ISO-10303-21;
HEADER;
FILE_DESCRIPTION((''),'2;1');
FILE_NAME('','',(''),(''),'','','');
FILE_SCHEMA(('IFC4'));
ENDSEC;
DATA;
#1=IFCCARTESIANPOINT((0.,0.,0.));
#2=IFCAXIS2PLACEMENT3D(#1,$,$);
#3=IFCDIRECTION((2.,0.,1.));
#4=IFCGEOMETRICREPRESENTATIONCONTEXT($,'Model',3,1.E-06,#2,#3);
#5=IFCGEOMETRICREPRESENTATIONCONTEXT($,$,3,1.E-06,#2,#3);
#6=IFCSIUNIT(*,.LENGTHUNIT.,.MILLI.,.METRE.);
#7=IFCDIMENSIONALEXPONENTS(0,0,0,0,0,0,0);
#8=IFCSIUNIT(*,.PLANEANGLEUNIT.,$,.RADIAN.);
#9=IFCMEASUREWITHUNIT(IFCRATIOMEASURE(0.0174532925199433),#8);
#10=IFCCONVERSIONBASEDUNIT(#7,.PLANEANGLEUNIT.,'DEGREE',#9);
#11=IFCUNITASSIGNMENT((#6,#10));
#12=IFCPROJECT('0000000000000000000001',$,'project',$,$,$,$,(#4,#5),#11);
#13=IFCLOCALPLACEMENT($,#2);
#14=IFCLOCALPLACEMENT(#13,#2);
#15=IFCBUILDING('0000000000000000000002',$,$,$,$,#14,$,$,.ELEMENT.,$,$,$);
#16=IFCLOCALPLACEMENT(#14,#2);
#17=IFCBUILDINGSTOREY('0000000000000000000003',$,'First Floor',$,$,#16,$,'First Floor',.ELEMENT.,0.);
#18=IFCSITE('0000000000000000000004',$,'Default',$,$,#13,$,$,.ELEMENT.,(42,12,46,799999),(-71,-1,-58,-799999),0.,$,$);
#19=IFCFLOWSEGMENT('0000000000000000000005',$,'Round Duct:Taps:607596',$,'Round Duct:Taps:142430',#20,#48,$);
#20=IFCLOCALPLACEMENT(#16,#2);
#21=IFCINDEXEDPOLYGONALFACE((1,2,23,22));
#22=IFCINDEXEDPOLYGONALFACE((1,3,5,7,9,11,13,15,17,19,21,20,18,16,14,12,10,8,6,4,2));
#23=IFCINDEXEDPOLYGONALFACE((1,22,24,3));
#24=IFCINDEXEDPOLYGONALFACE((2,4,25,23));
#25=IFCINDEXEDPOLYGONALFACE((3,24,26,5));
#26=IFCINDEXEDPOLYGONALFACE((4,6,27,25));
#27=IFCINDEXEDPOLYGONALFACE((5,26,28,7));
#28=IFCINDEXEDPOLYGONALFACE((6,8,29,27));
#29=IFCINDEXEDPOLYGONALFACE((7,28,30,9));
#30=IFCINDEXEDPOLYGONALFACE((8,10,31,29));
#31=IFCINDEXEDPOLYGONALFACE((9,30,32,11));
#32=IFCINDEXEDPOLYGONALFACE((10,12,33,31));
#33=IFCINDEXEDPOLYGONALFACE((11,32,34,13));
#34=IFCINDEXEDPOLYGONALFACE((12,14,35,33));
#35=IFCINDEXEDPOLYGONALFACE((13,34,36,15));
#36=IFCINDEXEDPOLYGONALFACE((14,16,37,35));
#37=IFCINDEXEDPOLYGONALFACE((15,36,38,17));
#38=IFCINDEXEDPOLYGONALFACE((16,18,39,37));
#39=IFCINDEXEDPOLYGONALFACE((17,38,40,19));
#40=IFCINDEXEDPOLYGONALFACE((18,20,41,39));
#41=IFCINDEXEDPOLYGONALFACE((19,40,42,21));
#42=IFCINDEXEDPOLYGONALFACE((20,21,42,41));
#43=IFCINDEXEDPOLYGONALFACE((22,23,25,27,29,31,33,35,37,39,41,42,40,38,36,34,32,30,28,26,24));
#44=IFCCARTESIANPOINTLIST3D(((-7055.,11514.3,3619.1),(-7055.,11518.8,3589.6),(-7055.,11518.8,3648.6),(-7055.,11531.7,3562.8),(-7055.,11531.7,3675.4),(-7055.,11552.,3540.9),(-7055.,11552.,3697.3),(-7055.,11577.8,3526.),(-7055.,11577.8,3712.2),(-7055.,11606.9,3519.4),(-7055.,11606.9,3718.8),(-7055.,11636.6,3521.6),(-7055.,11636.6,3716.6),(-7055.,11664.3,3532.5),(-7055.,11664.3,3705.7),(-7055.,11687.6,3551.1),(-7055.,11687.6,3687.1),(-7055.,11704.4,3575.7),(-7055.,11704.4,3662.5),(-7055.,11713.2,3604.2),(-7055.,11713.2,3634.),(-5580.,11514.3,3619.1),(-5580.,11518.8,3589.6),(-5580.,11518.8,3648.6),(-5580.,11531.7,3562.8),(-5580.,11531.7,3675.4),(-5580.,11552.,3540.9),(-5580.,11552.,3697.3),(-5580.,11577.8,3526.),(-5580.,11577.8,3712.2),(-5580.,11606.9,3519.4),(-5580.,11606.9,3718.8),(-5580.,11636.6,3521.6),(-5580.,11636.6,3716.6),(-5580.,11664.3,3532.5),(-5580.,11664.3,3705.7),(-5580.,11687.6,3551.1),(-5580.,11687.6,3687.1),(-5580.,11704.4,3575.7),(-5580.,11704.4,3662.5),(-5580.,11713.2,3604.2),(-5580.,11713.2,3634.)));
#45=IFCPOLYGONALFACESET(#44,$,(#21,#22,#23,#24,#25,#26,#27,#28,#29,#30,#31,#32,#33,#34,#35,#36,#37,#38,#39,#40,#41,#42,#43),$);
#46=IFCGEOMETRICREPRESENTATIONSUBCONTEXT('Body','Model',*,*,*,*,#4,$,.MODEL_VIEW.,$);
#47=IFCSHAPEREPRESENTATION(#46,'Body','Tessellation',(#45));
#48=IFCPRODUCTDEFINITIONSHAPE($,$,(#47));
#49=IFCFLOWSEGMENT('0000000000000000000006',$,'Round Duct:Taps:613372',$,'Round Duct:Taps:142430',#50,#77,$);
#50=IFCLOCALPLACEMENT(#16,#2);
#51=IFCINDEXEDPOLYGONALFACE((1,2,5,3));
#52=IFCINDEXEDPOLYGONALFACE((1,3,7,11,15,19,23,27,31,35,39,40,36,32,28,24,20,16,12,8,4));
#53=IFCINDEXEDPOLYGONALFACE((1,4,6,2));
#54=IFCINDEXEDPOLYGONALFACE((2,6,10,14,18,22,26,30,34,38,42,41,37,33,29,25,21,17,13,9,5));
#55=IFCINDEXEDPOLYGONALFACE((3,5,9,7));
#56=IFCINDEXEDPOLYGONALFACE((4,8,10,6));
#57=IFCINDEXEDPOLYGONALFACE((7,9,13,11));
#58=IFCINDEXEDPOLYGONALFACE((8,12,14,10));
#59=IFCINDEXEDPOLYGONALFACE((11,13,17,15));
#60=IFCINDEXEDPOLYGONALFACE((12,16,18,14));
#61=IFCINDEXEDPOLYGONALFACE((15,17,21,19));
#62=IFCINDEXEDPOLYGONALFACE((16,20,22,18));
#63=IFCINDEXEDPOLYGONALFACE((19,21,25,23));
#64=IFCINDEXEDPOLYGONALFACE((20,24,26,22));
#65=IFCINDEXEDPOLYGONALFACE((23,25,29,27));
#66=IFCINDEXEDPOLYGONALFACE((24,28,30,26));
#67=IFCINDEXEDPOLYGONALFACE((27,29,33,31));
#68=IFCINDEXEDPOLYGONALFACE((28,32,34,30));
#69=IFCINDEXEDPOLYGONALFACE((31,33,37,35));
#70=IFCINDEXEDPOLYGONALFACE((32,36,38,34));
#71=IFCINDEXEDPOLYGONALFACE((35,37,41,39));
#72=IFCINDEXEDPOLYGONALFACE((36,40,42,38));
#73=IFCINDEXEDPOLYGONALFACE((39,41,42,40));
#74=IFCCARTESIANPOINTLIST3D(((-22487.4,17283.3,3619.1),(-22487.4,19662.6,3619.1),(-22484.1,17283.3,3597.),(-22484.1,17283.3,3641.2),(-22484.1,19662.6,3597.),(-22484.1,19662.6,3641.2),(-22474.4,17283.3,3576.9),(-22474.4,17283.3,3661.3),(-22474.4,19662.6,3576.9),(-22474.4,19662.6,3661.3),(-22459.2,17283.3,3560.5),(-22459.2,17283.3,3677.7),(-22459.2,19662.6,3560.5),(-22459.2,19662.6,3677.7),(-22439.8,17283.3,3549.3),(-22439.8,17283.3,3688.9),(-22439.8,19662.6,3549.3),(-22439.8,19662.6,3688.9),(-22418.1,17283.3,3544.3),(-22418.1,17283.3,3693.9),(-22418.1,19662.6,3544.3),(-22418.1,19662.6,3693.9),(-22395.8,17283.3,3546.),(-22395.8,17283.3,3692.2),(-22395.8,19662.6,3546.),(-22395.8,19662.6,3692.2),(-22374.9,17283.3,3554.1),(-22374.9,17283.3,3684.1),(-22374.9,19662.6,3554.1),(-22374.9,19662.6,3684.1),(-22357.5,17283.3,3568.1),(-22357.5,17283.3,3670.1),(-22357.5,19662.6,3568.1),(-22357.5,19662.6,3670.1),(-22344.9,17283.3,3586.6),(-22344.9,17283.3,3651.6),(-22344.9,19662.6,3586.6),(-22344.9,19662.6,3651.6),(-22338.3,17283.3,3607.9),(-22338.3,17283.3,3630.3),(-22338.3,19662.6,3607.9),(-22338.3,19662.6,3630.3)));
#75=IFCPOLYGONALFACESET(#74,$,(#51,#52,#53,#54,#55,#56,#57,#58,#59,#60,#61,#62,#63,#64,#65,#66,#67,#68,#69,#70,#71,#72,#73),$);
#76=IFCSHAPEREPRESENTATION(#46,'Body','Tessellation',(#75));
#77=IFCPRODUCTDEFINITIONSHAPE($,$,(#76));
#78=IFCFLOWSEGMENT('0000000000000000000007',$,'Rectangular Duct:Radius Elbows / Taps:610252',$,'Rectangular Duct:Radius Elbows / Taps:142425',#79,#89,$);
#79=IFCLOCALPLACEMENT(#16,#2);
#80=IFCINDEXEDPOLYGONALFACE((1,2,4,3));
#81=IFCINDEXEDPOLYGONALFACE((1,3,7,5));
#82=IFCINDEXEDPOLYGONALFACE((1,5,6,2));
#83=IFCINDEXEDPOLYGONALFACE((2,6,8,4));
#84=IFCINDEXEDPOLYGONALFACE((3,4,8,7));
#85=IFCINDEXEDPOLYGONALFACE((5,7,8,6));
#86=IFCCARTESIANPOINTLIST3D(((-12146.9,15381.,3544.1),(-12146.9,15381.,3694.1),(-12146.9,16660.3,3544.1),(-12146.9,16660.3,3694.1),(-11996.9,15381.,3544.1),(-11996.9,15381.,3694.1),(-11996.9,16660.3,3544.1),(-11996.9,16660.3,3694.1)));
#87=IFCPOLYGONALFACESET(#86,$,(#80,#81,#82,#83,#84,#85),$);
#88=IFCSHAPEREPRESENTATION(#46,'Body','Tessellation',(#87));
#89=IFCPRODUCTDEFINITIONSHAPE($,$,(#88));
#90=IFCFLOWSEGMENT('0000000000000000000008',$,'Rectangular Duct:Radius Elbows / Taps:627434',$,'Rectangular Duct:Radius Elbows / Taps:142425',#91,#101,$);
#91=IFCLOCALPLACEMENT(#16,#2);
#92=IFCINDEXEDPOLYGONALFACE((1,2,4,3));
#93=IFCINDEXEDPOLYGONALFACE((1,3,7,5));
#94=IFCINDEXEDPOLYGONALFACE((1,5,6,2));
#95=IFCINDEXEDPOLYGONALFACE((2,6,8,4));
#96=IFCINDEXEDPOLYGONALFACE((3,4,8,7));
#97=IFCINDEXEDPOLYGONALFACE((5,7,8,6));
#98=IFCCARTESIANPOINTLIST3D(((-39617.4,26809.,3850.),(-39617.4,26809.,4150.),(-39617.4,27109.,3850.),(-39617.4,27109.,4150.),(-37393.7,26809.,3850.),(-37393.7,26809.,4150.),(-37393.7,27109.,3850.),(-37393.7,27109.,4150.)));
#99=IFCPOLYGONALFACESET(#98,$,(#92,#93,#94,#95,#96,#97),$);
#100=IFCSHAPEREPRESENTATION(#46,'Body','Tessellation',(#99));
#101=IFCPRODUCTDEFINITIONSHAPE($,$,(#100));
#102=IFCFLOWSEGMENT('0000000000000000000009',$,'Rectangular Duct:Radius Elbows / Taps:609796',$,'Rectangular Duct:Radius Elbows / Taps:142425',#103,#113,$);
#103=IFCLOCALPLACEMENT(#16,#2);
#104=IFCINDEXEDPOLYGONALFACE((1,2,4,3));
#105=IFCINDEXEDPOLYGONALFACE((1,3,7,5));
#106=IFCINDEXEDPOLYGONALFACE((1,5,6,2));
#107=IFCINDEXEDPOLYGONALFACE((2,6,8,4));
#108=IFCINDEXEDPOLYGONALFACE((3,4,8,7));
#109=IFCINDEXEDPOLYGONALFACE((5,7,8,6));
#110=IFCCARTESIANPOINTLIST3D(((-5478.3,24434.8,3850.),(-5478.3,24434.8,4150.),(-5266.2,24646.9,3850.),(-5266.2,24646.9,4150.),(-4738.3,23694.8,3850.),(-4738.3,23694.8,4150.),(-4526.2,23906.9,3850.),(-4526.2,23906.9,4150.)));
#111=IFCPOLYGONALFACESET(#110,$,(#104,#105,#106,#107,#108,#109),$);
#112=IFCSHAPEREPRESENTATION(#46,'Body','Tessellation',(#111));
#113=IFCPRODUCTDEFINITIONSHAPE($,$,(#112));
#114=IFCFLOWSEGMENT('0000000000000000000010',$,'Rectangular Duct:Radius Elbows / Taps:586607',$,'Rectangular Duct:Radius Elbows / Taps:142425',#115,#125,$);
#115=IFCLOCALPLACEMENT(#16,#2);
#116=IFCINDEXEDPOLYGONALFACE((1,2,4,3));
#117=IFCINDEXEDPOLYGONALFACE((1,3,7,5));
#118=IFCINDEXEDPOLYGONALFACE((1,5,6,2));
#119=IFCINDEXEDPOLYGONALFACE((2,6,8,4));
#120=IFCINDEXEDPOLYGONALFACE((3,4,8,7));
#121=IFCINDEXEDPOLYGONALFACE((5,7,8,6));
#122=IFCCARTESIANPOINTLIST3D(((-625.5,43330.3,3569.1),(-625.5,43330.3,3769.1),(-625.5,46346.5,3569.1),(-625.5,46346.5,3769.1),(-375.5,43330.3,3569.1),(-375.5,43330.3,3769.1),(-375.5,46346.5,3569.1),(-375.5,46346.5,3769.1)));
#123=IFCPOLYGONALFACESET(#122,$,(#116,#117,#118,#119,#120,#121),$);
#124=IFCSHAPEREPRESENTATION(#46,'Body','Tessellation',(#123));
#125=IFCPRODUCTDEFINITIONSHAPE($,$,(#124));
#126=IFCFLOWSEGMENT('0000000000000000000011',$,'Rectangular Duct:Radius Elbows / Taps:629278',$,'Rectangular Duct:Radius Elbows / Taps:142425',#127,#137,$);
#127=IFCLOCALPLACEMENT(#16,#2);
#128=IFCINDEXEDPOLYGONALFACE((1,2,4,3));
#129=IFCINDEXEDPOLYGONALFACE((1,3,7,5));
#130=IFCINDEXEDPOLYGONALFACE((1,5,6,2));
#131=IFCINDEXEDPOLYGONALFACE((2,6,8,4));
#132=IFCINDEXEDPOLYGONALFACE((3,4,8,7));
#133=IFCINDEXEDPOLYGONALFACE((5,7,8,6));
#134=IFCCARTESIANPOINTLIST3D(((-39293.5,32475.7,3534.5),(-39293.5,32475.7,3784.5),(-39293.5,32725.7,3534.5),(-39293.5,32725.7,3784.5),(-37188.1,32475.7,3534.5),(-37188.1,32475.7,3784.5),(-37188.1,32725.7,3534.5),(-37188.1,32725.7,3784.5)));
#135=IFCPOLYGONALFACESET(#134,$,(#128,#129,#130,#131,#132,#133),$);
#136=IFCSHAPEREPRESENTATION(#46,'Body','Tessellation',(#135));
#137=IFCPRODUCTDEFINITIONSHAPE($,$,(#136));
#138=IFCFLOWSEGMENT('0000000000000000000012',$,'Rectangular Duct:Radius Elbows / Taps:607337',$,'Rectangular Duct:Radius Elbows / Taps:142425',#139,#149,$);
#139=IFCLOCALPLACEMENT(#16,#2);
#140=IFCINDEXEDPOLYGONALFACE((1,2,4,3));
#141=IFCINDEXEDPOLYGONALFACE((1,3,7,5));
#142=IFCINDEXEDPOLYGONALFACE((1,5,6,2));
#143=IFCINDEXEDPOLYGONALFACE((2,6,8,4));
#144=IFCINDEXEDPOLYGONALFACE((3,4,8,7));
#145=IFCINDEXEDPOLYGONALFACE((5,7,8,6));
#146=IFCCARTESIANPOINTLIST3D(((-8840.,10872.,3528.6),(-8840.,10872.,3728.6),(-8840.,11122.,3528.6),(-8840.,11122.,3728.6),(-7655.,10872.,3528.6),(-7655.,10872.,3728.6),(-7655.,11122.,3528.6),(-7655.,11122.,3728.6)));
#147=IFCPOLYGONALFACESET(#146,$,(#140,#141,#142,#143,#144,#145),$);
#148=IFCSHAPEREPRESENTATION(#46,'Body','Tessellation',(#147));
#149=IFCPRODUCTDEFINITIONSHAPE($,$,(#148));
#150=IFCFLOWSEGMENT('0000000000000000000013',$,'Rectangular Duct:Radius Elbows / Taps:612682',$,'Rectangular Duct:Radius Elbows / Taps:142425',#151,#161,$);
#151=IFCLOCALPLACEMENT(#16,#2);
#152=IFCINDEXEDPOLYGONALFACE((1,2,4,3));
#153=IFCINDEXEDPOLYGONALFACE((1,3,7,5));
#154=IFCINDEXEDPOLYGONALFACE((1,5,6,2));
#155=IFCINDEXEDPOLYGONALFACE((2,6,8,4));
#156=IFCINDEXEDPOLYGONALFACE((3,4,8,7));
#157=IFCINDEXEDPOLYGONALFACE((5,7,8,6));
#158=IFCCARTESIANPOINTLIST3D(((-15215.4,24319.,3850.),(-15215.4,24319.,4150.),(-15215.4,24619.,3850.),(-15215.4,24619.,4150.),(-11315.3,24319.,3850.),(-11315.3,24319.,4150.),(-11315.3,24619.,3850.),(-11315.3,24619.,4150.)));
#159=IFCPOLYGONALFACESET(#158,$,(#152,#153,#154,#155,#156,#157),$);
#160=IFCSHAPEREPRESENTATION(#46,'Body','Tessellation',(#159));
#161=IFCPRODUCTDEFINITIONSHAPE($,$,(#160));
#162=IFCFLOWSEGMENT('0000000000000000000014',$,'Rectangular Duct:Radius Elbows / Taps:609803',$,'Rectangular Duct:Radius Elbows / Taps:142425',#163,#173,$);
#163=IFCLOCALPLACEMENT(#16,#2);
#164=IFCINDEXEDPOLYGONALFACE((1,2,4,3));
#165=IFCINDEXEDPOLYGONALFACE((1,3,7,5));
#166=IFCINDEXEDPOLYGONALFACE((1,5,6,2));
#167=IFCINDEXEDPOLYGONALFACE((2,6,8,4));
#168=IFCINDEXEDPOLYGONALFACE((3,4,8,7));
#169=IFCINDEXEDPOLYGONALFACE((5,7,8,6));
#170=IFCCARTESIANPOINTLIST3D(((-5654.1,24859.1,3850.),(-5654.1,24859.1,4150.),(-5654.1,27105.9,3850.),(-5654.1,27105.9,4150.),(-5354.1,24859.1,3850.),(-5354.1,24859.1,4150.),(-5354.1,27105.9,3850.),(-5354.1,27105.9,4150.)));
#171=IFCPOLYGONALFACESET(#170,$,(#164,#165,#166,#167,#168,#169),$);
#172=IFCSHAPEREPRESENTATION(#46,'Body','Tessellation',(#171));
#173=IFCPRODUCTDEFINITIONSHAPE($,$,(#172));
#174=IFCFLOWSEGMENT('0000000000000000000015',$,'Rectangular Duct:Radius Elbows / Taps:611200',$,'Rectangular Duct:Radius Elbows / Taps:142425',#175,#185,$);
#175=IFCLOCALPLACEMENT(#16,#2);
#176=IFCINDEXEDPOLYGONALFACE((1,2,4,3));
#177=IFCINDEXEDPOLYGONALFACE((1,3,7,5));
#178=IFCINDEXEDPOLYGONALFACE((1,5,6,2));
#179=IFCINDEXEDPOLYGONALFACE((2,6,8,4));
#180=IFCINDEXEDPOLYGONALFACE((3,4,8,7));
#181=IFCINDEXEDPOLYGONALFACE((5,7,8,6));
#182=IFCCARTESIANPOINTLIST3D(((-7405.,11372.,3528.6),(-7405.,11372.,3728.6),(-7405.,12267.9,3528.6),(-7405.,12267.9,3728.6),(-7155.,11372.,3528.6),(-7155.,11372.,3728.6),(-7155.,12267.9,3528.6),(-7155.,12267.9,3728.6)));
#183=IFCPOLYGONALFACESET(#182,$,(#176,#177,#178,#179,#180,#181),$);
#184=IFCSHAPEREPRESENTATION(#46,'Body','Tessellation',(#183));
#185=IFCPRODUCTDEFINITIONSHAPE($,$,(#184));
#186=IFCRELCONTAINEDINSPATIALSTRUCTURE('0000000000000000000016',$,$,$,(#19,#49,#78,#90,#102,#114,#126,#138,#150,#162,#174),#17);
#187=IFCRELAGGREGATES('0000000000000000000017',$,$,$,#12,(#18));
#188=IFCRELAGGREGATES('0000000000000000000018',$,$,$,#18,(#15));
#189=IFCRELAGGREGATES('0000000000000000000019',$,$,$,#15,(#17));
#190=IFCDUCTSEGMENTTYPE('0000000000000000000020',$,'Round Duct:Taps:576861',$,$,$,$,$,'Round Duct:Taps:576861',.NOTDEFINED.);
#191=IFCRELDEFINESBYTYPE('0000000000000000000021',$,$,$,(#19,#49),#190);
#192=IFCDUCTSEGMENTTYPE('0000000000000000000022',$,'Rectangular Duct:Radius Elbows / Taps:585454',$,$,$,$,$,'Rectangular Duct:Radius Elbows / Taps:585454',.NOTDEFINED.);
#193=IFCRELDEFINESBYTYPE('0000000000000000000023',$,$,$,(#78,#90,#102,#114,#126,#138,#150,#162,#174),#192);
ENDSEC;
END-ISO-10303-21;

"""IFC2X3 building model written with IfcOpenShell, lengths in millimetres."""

from ifc_helpers import new_model, entity, si_unit, converted_unit, direction, frame, frame_2d, origin, origin_2d_with_axis, place, context, subcontext, project, spatial, rectangle, circle, extrude, type_object, element, save


model = new_model("IFC2X3")

# Units and contexts
model_context = context("Model", 3, precision=1e-06, world=origin(), true_north=direction((2.0, 0.0, 1.0)))
context_of_model = context(None, 3, precision=1e-06, world=origin(), true_north=direction((2.0, 0.0, 1.0)))
body_context = subcontext(model_context, "Body", "Model", "MODEL_VIEW")
ifc_project = project(units=[si_unit("LENGTHUNIT", "METRE", prefix="MILLI"), converted_unit("PLANEANGLEUNIT", "DEGREE", entity("IfcRatioMeasure", 0.0174532925199433), si_unit("PLANEANGLEUNIT", "RADIAN"), dimensions=[0, 0, 0, 0, 0, 0, 0])], contexts=[model_context, context_of_model])

# Site, building, storey
site_placement = place(None, origin())
site = spatial("IfcSite", under=ifc_project, at=site_placement, Name="Default", CompositionType="ELEMENT", RefLatitude=(42, 12, 46, 799999), RefLongitude=(-71, -1, -58, -799999), RefElevation=0.0)
building_placement = place(site_placement, origin())
building = spatial("IfcBuilding", under=site, at=building_placement, CompositionType="ELEMENT")
storey_placement = place(building_placement, origin())
storey = spatial("IfcBuildingStorey", under=building, at=storey_placement, Name="First Floor", LongName="First Floor", CompositionType="ELEMENT", Elevation=0.0)

# Flow segments
duct_segment_type_1 = type_object("IfcDuctSegmentType", Name="Round Duct:Taps:576861", ElementType="Round Duct:Taps:576861", PredefinedType="NOTDEFINED")
flow_segment_1_placement = place(storey_placement, origin())
element("IfcFlowSegment", 1, at=flow_segment_1_placement, inside=storey, type_object=duct_segment_type_1, Name="Round Duct:Taps:607596", ObjectType="Round Duct:Taps:142430", context=body_context, shape_type="SweptSolid", body=[
    extrude(circle(Radius=100.0, at=origin_2d_with_axis()), frame((-7055.0, 11614.3, 3619.1), z_axis=(1.0, 0.0, 0.0), x_axis=(0.0, -1.0, 0.0)), (0.0, 0.0, 1.0), 1475.0),
])
flow_segment_2_placement = place(storey_placement, origin())
element("IfcFlowSegment", 2, at=flow_segment_2_placement, inside=storey, type_object=duct_segment_type_1, Name="Round Duct:Taps:613372", ObjectType="Round Duct:Taps:142430", context=body_context, shape_type="SweptSolid", body=[
    extrude(circle(Radius=75.0, at=frame_2d((0.0, 0.0), x_axis=(1.0, 0.0))), frame((-22412.4, 17283.3, 3619.1), z_axis=(0.0, 1.0, 0.0), x_axis=(-1.0, 0.0, 0.0)), (0.0, 0.0, 1.0), 2379.3),
])
duct_segment_type_2 = type_object("IfcDuctSegmentType", Name="Rectangular Duct:Radius Elbows / Taps:585454", ElementType="Rectangular Duct:Radius Elbows / Taps:585454", PredefinedType="NOTDEFINED")
flow_segment_3_placement = place(storey_placement, origin())
element("IfcFlowSegment", 3, at=flow_segment_3_placement, inside=storey, type_object=duct_segment_type_2, Name="Rectangular Duct:Radius Elbows / Taps:610252", ObjectType="Rectangular Duct:Radius Elbows / Taps:142425", context=body_context, shape_type="SweptSolid", body=[
    extrude(rectangle(XDim=1279.3, YDim=150.0, at=origin_2d_with_axis()), frame((-12071.9, 16020.7, 3544.1), z_axis=(0.0, 0.0, 1.0), x_axis=(0.0, 1.0, 0.0)), (0.0, 0.0, 1.0), 150.0),
])
flow_segment_4_placement = place(storey_placement, origin())
element("IfcFlowSegment", 4, at=flow_segment_4_placement, inside=storey, type_object=duct_segment_type_2, Name="Rectangular Duct:Radius Elbows / Taps:627434", ObjectType="Rectangular Duct:Radius Elbows / Taps:142425", context=body_context, shape_type="SweptSolid", body=[
    extrude(rectangle(XDim=2223.8, YDim=300.0, at=frame_2d((0.0, 0.0), x_axis=(1.0, 0.0))), frame((-38505.5, 26959.0, 3850.0), z_axis=(0.0, 0.0, 1.0), x_axis=(-1.0, 0.0, 0.0)), (0.0, 0.0, 1.0), 300.0),
])
flow_segment_5_placement = place(storey_placement, origin())
element("IfcFlowSegment", 5, at=flow_segment_5_placement, inside=storey, type_object=duct_segment_type_2, Name="Rectangular Duct:Radius Elbows / Taps:609796", ObjectType="Rectangular Duct:Radius Elbows / Taps:142425", context=body_context, shape_type="SweptSolid", body=[
    extrude(rectangle(XDim=1046.6, YDim=300.0, at=frame_2d((0.0, 0.0), x_axis=(1.0, 0.0))), frame((-5002.3, 24170.9, 3850.0), z_axis=(0.0, 0.0, 1.0), x_axis=(-0.707107, 0.707107, 0.0)), (0.0, 0.0, 1.0), 300.0),
])
flow_segment_6_placement = place(storey_placement, origin())
element("IfcFlowSegment", 6, at=flow_segment_6_placement, inside=storey, type_object=duct_segment_type_2, Name="Rectangular Duct:Radius Elbows / Taps:586607", ObjectType="Rectangular Duct:Radius Elbows / Taps:142425", context=body_context, shape_type="SweptSolid", body=[
    extrude(rectangle(XDim=3016.1, YDim=250.0, at=frame_2d((0.0, 0.0), x_axis=(1.0, 0.0))), frame((-500.5, 44838.4, 3569.1), z_axis=(0.0, 0.0, 1.0), x_axis=(0.0, 1.0, 0.0)), (0.0, 0.0, 1.0), 200.0),
])
flow_segment_7_placement = place(storey_placement, origin())
element("IfcFlowSegment", 7, at=flow_segment_7_placement, inside=storey, type_object=duct_segment_type_2, Name="Rectangular Duct:Radius Elbows / Taps:629278", ObjectType="Rectangular Duct:Radius Elbows / Taps:142425", context=body_context, shape_type="SweptSolid", body=[
    extrude(rectangle(XDim=2105.4, YDim=250.0, at=frame_2d((0.0, 0.0), x_axis=(1.0, 0.0))), frame((-38240.8, 32600.7, 3534.5)), (0.0, 0.0, 1.0), 250.0),
])
flow_segment_8_placement = place(storey_placement, origin())
element("IfcFlowSegment", 8, at=flow_segment_8_placement, inside=storey, type_object=duct_segment_type_2, Name="Rectangular Duct:Radius Elbows / Taps:607337", ObjectType="Rectangular Duct:Radius Elbows / Taps:142425", context=body_context, shape_type="SweptSolid", body=[
    extrude(rectangle(XDim=1185.0, YDim=250.0, at=frame_2d((0.0, 0.0), x_axis=(1.0, 0.0))), frame((-8247.5, 10997.0, 3528.6), z_axis=(0.0, 0.0, 1.0), x_axis=(-1.0, 0.0, 0.0)), (0.0, 0.0, 1.0), 200.0),
])
flow_segment_9_placement = place(storey_placement, origin())
element("IfcFlowSegment", 9, at=flow_segment_9_placement, inside=storey, type_object=duct_segment_type_2, Name="Rectangular Duct:Radius Elbows / Taps:612682", ObjectType="Rectangular Duct:Radius Elbows / Taps:142425", context=body_context, shape_type="SweptSolid", body=[
    extrude(rectangle(XDim=3900.1, YDim=300.0, at=origin_2d_with_axis()), frame((-13265.4, 24469.0, 3850.0), z_axis=(0.0, 0.0, 1.0), x_axis=(-1.0, 0.0, 0.0)), (0.0, 0.0, 1.0), 300.0),
])
flow_segment_10_placement = place(storey_placement, origin())
element("IfcFlowSegment", 10, at=flow_segment_10_placement, inside=storey, type_object=duct_segment_type_2, Name="Rectangular Duct:Radius Elbows / Taps:609803", ObjectType="Rectangular Duct:Radius Elbows / Taps:142425", context=body_context, shape_type="SweptSolid", body=[
    extrude(rectangle(XDim=2246.8, YDim=300.0, at=frame_2d((0.0, 0.0), x_axis=(1.0, 0.0))), frame((-5504.1, 25982.5, 3850.0), z_axis=(0.0, 0.0, 1.0), x_axis=(0.0, 1.0, 0.0)), (0.0, 0.0, 1.0), 300.0),
])
flow_segment_11_placement = place(storey_placement, origin())
element("IfcFlowSegment", 11, at=flow_segment_11_placement, inside=storey, type_object=duct_segment_type_2, Name="Rectangular Duct:Radius Elbows / Taps:611200", ObjectType="Rectangular Duct:Radius Elbows / Taps:142425", context=body_context, shape_type="SweptSolid", body=[
    extrude(rectangle(XDim=895.9, YDim=250.0, at=frame_2d((0.0, 0.0), x_axis=(1.0, 0.0))), frame((-7280.0, 11820.0, 3528.6), z_axis=(0.0, 0.0, 1.0), x_axis=(0.0, -1.0, 0.0)), (0.0, 0.0, 1.0), 200.0),
])

save(model, "model.ifc")
